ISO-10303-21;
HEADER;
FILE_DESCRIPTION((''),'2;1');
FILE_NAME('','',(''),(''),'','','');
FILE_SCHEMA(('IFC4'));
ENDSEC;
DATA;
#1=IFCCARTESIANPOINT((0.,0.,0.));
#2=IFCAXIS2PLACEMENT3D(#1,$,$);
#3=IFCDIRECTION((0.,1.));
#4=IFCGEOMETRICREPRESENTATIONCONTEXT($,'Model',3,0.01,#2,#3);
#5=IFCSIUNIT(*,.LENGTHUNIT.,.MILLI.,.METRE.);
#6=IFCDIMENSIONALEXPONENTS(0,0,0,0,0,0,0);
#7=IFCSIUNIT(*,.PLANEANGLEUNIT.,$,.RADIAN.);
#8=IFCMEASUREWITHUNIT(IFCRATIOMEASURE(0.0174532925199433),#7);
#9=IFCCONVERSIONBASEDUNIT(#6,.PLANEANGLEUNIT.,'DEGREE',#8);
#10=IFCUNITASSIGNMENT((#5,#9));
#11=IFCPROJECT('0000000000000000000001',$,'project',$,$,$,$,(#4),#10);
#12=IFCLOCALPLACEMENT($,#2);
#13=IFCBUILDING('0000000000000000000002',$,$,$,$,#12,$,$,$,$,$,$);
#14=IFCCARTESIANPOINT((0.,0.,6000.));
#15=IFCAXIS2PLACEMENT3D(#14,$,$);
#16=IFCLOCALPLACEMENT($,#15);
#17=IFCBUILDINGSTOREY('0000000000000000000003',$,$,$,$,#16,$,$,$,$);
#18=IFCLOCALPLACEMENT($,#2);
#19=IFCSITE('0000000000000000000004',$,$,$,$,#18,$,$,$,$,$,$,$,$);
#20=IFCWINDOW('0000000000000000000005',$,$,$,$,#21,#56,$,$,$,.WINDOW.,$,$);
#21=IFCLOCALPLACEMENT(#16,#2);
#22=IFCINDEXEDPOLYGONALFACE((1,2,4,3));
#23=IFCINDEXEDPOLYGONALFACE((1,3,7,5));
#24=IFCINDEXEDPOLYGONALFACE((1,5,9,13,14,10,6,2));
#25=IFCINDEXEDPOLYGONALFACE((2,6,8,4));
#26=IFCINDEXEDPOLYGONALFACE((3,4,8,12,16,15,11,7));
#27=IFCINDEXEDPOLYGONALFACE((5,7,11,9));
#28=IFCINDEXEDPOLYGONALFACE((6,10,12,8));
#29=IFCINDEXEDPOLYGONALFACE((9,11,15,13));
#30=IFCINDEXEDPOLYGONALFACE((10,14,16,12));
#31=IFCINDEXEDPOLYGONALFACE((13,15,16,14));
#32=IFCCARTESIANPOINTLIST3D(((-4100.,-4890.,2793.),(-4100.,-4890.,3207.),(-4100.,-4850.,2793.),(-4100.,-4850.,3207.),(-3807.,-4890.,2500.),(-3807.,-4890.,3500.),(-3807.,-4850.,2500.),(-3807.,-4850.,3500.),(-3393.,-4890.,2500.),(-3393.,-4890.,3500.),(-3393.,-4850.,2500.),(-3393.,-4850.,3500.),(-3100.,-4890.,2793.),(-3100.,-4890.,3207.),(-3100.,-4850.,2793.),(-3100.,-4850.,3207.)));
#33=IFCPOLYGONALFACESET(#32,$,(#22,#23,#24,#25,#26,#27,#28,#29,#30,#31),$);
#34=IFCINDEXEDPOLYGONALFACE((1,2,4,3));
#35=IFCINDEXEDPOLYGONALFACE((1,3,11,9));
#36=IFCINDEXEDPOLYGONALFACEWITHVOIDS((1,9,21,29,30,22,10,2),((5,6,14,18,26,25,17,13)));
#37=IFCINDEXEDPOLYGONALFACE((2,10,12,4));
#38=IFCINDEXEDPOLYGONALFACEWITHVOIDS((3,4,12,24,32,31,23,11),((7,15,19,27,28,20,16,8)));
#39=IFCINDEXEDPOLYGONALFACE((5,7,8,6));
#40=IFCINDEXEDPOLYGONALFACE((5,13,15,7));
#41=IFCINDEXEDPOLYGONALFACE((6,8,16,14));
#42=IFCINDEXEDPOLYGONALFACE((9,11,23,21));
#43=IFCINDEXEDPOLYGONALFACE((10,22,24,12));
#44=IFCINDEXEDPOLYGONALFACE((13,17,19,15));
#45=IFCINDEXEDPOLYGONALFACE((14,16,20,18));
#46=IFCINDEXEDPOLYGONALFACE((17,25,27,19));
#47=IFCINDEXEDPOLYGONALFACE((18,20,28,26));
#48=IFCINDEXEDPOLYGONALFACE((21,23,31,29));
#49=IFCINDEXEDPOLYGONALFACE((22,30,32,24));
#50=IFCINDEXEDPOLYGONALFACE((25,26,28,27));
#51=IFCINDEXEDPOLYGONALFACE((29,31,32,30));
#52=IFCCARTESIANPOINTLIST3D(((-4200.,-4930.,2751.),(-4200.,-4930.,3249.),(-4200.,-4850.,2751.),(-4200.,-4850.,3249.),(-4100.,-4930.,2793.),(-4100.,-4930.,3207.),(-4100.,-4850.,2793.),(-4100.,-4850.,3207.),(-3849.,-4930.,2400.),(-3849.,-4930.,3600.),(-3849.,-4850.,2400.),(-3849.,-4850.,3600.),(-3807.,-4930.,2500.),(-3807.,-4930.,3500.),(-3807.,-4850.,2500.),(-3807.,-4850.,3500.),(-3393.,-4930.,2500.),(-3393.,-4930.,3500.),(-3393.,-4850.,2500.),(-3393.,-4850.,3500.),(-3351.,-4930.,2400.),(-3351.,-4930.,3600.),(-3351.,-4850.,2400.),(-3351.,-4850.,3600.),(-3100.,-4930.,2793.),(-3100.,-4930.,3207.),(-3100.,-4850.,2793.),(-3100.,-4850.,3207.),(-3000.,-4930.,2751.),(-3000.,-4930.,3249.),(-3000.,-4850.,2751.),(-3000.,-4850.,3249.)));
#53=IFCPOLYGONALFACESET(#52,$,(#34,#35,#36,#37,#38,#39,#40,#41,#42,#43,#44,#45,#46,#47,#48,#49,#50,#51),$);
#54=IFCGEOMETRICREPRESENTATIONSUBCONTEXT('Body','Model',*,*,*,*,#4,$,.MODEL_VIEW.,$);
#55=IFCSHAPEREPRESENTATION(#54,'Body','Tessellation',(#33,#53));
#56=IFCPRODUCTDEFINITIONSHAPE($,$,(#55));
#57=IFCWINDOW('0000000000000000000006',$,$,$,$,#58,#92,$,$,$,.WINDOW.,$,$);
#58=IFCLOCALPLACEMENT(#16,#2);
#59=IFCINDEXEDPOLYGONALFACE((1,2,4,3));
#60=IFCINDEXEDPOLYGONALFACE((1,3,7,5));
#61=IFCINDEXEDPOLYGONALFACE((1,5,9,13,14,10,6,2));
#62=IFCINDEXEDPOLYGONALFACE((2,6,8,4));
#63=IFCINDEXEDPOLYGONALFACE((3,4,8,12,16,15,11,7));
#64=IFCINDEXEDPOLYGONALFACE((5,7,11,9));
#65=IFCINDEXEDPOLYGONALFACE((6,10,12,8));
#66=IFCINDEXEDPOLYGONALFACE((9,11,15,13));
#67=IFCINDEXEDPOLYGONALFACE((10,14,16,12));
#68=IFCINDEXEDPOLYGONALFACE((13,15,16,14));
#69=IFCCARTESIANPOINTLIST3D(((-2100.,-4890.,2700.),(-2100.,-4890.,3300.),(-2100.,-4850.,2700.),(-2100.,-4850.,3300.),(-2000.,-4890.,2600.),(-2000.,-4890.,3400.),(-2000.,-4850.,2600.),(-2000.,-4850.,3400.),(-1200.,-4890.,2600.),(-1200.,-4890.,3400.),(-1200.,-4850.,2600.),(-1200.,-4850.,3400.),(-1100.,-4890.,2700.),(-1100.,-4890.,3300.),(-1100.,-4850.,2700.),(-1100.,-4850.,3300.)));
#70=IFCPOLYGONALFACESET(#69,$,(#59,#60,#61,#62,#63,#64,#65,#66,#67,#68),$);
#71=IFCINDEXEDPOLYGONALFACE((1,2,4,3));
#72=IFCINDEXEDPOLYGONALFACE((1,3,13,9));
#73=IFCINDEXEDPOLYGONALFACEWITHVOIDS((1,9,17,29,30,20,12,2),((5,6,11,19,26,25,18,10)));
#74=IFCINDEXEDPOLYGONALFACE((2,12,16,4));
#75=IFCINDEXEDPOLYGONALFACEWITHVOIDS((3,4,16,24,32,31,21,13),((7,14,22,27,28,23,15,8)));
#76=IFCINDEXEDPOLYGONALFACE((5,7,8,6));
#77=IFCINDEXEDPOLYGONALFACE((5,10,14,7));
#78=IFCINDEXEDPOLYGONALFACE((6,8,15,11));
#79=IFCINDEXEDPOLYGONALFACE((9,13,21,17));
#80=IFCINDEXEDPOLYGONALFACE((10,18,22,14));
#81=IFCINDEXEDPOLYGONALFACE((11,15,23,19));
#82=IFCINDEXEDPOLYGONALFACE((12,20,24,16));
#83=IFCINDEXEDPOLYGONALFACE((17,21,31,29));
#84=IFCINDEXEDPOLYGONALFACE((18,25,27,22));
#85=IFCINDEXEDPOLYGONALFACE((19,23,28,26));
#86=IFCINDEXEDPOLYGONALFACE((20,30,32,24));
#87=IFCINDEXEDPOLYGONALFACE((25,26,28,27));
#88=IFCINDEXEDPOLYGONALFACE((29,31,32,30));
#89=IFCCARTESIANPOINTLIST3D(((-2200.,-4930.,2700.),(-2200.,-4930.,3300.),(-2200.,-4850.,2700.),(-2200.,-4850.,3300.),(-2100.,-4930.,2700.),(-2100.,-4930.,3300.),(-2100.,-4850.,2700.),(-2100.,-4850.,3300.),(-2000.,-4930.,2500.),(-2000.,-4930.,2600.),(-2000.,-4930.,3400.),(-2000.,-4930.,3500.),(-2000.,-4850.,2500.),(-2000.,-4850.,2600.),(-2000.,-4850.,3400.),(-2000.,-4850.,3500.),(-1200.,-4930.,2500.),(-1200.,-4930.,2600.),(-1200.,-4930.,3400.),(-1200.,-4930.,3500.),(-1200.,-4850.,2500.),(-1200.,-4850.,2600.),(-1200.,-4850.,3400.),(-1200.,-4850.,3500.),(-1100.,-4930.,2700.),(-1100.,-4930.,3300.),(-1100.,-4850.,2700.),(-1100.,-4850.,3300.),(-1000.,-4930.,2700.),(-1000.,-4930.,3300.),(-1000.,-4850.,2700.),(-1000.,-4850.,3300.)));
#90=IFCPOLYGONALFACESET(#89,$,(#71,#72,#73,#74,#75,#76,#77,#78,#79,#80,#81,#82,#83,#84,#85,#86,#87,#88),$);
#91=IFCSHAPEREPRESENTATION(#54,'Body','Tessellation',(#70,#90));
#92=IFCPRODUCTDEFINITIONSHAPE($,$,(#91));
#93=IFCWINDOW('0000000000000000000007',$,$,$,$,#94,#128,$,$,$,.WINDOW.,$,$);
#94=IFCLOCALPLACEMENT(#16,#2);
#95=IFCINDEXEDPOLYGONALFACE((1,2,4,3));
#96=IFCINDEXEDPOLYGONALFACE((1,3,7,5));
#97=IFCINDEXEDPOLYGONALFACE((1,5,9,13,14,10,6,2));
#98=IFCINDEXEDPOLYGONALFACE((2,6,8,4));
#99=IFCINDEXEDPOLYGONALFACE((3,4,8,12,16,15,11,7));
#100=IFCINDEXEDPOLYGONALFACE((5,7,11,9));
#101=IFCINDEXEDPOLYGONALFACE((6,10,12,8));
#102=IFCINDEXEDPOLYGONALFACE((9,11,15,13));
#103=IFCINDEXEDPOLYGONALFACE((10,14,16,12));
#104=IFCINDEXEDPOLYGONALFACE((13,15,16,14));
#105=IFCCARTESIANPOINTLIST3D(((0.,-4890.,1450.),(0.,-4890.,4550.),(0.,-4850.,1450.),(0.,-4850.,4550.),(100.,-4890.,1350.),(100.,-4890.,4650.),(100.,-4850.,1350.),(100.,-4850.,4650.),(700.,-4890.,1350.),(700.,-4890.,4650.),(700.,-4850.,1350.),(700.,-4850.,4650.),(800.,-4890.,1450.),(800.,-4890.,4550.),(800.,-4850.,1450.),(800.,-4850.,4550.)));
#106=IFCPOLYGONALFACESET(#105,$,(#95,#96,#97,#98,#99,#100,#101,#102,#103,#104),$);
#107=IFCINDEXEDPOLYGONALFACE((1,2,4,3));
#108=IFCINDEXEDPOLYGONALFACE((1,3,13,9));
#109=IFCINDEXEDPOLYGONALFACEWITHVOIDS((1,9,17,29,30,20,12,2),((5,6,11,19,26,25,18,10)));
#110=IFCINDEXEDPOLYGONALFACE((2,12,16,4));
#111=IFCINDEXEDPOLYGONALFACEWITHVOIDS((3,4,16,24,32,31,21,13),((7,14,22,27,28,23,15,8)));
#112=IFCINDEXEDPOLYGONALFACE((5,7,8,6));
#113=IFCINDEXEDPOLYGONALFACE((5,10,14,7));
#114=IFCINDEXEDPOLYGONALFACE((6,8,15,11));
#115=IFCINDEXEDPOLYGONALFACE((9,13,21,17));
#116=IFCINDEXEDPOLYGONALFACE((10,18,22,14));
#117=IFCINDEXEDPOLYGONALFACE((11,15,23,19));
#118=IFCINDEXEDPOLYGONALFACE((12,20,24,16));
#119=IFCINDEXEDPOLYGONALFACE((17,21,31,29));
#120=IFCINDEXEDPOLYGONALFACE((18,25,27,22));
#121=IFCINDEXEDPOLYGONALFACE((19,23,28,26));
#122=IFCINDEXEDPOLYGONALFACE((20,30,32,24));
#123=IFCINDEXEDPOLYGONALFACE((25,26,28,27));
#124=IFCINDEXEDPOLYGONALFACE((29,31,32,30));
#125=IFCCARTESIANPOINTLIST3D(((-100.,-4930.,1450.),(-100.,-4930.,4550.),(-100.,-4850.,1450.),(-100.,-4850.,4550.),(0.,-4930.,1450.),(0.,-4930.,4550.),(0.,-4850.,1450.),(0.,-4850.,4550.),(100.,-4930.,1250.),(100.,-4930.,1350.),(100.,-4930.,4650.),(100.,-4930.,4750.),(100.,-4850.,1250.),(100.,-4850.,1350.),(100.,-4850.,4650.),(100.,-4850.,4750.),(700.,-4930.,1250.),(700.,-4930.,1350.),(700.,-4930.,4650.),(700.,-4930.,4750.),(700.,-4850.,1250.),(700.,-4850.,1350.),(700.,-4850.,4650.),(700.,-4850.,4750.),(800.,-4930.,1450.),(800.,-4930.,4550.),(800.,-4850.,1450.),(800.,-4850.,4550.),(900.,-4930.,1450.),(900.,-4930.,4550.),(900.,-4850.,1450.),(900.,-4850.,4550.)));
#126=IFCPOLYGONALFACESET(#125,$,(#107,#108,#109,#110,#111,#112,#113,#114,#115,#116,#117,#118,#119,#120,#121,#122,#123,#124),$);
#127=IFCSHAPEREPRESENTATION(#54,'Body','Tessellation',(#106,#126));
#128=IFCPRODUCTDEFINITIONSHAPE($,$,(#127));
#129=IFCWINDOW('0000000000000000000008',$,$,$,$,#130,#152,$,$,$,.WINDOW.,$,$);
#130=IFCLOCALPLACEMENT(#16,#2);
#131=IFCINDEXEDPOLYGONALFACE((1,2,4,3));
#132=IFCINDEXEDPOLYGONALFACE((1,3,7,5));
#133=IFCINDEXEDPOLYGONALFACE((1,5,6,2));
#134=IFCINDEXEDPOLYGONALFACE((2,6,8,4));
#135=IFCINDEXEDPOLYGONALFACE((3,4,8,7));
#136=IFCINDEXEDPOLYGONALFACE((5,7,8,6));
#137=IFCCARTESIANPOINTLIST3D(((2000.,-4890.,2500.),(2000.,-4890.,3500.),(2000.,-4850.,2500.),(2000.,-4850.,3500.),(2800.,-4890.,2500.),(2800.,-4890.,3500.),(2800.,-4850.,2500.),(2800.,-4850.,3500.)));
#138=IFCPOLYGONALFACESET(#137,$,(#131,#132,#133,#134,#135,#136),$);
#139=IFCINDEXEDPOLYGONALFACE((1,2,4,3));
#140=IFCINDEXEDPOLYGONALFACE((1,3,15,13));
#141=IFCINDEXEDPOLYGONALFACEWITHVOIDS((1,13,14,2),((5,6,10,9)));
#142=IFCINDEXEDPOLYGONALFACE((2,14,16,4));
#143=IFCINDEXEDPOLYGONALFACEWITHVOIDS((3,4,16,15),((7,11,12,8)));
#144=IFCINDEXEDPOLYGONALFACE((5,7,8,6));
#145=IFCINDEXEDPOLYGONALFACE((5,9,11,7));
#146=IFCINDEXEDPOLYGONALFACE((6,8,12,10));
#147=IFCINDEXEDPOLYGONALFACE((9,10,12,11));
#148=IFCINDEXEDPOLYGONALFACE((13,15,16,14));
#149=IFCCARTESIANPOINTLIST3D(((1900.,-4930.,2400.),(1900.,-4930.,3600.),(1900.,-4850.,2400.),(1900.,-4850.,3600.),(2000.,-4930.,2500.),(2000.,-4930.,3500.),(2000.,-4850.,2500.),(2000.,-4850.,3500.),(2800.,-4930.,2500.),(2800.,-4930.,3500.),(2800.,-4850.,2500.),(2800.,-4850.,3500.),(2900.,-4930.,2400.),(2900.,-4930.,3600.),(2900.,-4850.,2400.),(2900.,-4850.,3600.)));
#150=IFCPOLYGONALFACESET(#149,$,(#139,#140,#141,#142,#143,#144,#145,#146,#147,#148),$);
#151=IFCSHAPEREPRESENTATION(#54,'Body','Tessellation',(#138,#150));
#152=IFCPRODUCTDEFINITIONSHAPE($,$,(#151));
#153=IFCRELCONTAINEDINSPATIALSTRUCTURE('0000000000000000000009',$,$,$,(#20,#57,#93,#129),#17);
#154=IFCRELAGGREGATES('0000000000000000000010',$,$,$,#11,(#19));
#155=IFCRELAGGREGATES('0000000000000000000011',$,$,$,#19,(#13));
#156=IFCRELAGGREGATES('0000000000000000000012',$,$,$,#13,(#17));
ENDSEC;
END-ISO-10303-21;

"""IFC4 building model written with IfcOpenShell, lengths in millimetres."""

from ifc_helpers import new_model, entity, si_unit, converted_unit, direction, frame, origin, place, context, subcontext, project, spatial, element, save


model = new_model("IFC4")

# Units and contexts
model_context = context("Model", 3, precision=0.01, world=origin(), true_north=direction((0.0, 1.0)))
body_context = subcontext(model_context, "Body", "Model", "MODEL_VIEW")
ifc_project = project(units=[si_unit("LENGTHUNIT", "METRE", prefix="MILLI"), converted_unit("PLANEANGLEUNIT", "DEGREE", entity("IfcRatioMeasure", 0.0174532925199433), si_unit("PLANEANGLEUNIT", "RADIAN"), dimensions=[0, 0, 0, 0, 0, 0, 0])], contexts=[model_context])

# Site, building, storey
site_placement = place(None, origin())
site = spatial("IfcSite", under=ifc_project, at=site_placement)
building_placement = place(None, origin())
building = spatial("IfcBuilding", under=site, at=building_placement)
storey_placement = place(None, frame((0.0, 0.0, 6000.0)))
storey = spatial("IfcBuildingStorey", under=building, at=storey_placement)

# Shared definitions
cartesian_point_1 = entity("IfcCartesianPoint", [-500.0, -207.0])
shared_polyline_1 = entity("IfcPolyline", [cartesian_point_1, entity("IfcCartesianPoint", [-500.0, 207.0]), entity("IfcCartesianPoint", [-207.0, 500.0]), entity("IfcCartesianPoint", [207.0, 500.0]), entity("IfcCartesianPoint", [500.0, 207.0]), entity("IfcCartesianPoint", [500.0, -207.0]), entity("IfcCartesianPoint", [207.0, -500.0]), entity("IfcCartesianPoint", [-207.0, -500.0]), cartesian_point_1])
cartesian_point_2 = entity("IfcCartesianPoint", [-500.0, -300.0])
shared_polyline_2 = entity("IfcPolyline", [cartesian_point_2, entity("IfcCartesianPoint", [-500.0, 300.0]), entity("IfcCartesianPoint", [-400.0, 400.0]), entity("IfcCartesianPoint", [400.0, 400.0]), entity("IfcCartesianPoint", [500.0, 300.0]), entity("IfcCartesianPoint", [500.0, -300.0]), entity("IfcCartesianPoint", [400.0, -400.0]), entity("IfcCartesianPoint", [-400.0, -400.0]), cartesian_point_2])
cartesian_point_3 = entity("IfcCartesianPoint", [-400.0, -1550.0])
shared_polyline_3 = entity("IfcPolyline", [cartesian_point_3, entity("IfcCartesianPoint", [-400.0, 1550.0]), entity("IfcCartesianPoint", [-300.0, 1650.0]), entity("IfcCartesianPoint", [300.0, 1650.0]), entity("IfcCartesianPoint", [400.0, 1550.0]), entity("IfcCartesianPoint", [400.0, -1550.0]), entity("IfcCartesianPoint", [300.0, -1650.0]), entity("IfcCartesianPoint", [-300.0, -1650.0]), cartesian_point_3])
cartesian_point_4 = entity("IfcCartesianPoint", [-400.0, -500.0])
shared_polyline_4 = entity("IfcPolyline", [cartesian_point_4, entity("IfcCartesianPoint", [-400.0, 500.0]), entity("IfcCartesianPoint", [-400.0, 500.0]), entity("IfcCartesianPoint", [400.0, 500.0]), entity("IfcCartesianPoint", [400.0, 500.0]), entity("IfcCartesianPoint", [400.0, -500.0]), entity("IfcCartesianPoint", [400.0, -500.0]), entity("IfcCartesianPoint", [-400.0, -500.0]), cartesian_point_4])

# Shared definitions
wall_1_placement = place(storey_placement, frame((-100.0, -4900.0, 0.0), z_axis=(0.0, 0.0, 1.0), x_axis=(1.0, 0.0, 0.0)))
window_1_placement = place(wall_1_placement, frame((-3500.0, 50.0, 3000.0)))
window_2_placement = place(wall_1_placement, frame((-1500.0, 50.0, 3000.0)))
window_3_placement = place(wall_1_placement, frame((500.0, 50.0, 3000.0)))
window_4_placement = place(wall_1_placement, frame((2500.0, 50.0, 3000.0)))

# Windows
cartesian_point_5 = entity("IfcCartesianPoint", [-600.0, -249.0])
element("IfcWindow", 1, at=window_1_placement, inside=storey, PredefinedType="WINDOW", context=body_context, shape_type="SweptSolid", body=[
    entity("IfcExtrudedAreaSolid", entity("IfcArbitraryClosedProfileDef", "AREA", None, shared_polyline_1), entity("IfcAxis2Placement3D", entity("IfcCartesianPoint", [0.0, 0.0, 0.0]), entity("IfcDirection", [0.0, -1.0, 0.0]), entity("IfcDirection", [1.0, 0.0, 0.0])), entity("IfcDirection", [0.0, 0.0, 1.0]), 40.0),
    entity("IfcExtrudedAreaSolid", entity("IfcArbitraryProfileDefWithVoids", "AREA", None, entity("IfcPolyline", [cartesian_point_5, entity("IfcCartesianPoint", [-600.0, 249.0]), entity("IfcCartesianPoint", [-249.0, 600.0]), entity("IfcCartesianPoint", [249.0, 600.0]), entity("IfcCartesianPoint", [600.0, 249.0]), entity("IfcCartesianPoint", [600.0, -249.0]), entity("IfcCartesianPoint", [249.0, -600.0]), entity("IfcCartesianPoint", [-249.0, -600.0]), cartesian_point_5]), [shared_polyline_1]), entity("IfcAxis2Placement3D", entity("IfcCartesianPoint", [0.0, 0.0, 0.0]), entity("IfcDirection", [0.0, -1.0, 0.0]), entity("IfcDirection", [1.0, 0.0, 0.0])), entity("IfcDirection", [0.0, 0.0, 1.0]), 80.0),
])
cartesian_point_6 = entity("IfcCartesianPoint", [-600.0, -300.0])
element("IfcWindow", 2, at=window_2_placement, inside=storey, PredefinedType="WINDOW", context=body_context, shape_type="SweptSolid", body=[
    entity("IfcExtrudedAreaSolid", entity("IfcArbitraryClosedProfileDef", "AREA", None, shared_polyline_2), entity("IfcAxis2Placement3D", entity("IfcCartesianPoint", [0.0, 0.0, 0.0]), entity("IfcDirection", [0.0, -1.0, 0.0]), entity("IfcDirection", [1.0, 0.0, 0.0])), entity("IfcDirection", [0.0, 0.0, 1.0]), 40.0),
    entity("IfcExtrudedAreaSolid", entity("IfcArbitraryProfileDefWithVoids", "AREA", None, entity("IfcPolyline", [cartesian_point_6, entity("IfcCartesianPoint", [-600.0, 300.0]), entity("IfcCartesianPoint", [-400.0, 500.0]), entity("IfcCartesianPoint", [400.0, 500.0]), entity("IfcCartesianPoint", [600.0, 300.0]), entity("IfcCartesianPoint", [600.0, -300.0]), entity("IfcCartesianPoint", [400.0, -500.0]), entity("IfcCartesianPoint", [-400.0, -500.0]), cartesian_point_6]), [shared_polyline_2]), entity("IfcAxis2Placement3D", entity("IfcCartesianPoint", [0.0, 0.0, 0.0]), entity("IfcDirection", [0.0, -1.0, 0.0]), entity("IfcDirection", [1.0, 0.0, 0.0])), entity("IfcDirection", [0.0, 0.0, 1.0]), 80.0),
])
cartesian_point_7 = entity("IfcCartesianPoint", [-500.0, -1550.0])
element("IfcWindow", 3, at=window_3_placement, inside=storey, PredefinedType="WINDOW", context=body_context, shape_type="SweptSolid", body=[
    entity("IfcExtrudedAreaSolid", entity("IfcArbitraryClosedProfileDef", "AREA", None, shared_polyline_3), entity("IfcAxis2Placement3D", entity("IfcCartesianPoint", [0.0, 0.0, 0.0]), entity("IfcDirection", [0.0, -1.0, 0.0]), entity("IfcDirection", [1.0, 0.0, 0.0])), entity("IfcDirection", [0.0, 0.0, 1.0]), 40.0),
    entity("IfcExtrudedAreaSolid", entity("IfcArbitraryProfileDefWithVoids", "AREA", None, entity("IfcPolyline", [cartesian_point_7, entity("IfcCartesianPoint", [-500.0, 1550.0]), entity("IfcCartesianPoint", [-300.0, 1750.0]), entity("IfcCartesianPoint", [300.0, 1750.0]), entity("IfcCartesianPoint", [500.0, 1550.0]), entity("IfcCartesianPoint", [500.0, -1550.0]), entity("IfcCartesianPoint", [300.0, -1750.0]), entity("IfcCartesianPoint", [-300.0, -1750.0]), cartesian_point_7]), [shared_polyline_3]), entity("IfcAxis2Placement3D", entity("IfcCartesianPoint", [0.0, 0.0, 0.0]), entity("IfcDirection", [0.0, -1.0, 0.0]), entity("IfcDirection", [1.0, 0.0, 0.0])), entity("IfcDirection", [0.0, 0.0, 1.0]), 80.0),
])
cartesian_point_8 = entity("IfcCartesianPoint", [-500.0, -600.0])
element("IfcWindow", 4, at=window_4_placement, inside=storey, PredefinedType="WINDOW", context=body_context, shape_type="SweptSolid", body=[
    entity("IfcExtrudedAreaSolid", entity("IfcArbitraryClosedProfileDef", "AREA", None, shared_polyline_4), entity("IfcAxis2Placement3D", entity("IfcCartesianPoint", [0.0, 0.0, 0.0]), entity("IfcDirection", [0.0, -1.0, 0.0]), entity("IfcDirection", [1.0, 0.0, 0.0])), entity("IfcDirection", [0.0, 0.0, 1.0]), 40.0),
    entity("IfcExtrudedAreaSolid", entity("IfcArbitraryProfileDefWithVoids", "AREA", None, entity("IfcPolyline", [cartesian_point_8, entity("IfcCartesianPoint", [-500.0, 600.0]), entity("IfcCartesianPoint", [-500.0, 600.0]), entity("IfcCartesianPoint", [500.0, 600.0]), entity("IfcCartesianPoint", [500.0, 600.0]), entity("IfcCartesianPoint", [500.0, -600.0]), entity("IfcCartesianPoint", [500.0, -600.0]), entity("IfcCartesianPoint", [-500.0, -600.0]), cartesian_point_8]), [shared_polyline_4]), entity("IfcAxis2Placement3D", entity("IfcCartesianPoint", [0.0, 0.0, 0.0]), entity("IfcDirection", [0.0, -1.0, 0.0]), entity("IfcDirection", [1.0, 0.0, 0.0])), entity("IfcDirection", [0.0, 0.0, 1.0]), 80.0),
])

save(model, "model.ifc")
